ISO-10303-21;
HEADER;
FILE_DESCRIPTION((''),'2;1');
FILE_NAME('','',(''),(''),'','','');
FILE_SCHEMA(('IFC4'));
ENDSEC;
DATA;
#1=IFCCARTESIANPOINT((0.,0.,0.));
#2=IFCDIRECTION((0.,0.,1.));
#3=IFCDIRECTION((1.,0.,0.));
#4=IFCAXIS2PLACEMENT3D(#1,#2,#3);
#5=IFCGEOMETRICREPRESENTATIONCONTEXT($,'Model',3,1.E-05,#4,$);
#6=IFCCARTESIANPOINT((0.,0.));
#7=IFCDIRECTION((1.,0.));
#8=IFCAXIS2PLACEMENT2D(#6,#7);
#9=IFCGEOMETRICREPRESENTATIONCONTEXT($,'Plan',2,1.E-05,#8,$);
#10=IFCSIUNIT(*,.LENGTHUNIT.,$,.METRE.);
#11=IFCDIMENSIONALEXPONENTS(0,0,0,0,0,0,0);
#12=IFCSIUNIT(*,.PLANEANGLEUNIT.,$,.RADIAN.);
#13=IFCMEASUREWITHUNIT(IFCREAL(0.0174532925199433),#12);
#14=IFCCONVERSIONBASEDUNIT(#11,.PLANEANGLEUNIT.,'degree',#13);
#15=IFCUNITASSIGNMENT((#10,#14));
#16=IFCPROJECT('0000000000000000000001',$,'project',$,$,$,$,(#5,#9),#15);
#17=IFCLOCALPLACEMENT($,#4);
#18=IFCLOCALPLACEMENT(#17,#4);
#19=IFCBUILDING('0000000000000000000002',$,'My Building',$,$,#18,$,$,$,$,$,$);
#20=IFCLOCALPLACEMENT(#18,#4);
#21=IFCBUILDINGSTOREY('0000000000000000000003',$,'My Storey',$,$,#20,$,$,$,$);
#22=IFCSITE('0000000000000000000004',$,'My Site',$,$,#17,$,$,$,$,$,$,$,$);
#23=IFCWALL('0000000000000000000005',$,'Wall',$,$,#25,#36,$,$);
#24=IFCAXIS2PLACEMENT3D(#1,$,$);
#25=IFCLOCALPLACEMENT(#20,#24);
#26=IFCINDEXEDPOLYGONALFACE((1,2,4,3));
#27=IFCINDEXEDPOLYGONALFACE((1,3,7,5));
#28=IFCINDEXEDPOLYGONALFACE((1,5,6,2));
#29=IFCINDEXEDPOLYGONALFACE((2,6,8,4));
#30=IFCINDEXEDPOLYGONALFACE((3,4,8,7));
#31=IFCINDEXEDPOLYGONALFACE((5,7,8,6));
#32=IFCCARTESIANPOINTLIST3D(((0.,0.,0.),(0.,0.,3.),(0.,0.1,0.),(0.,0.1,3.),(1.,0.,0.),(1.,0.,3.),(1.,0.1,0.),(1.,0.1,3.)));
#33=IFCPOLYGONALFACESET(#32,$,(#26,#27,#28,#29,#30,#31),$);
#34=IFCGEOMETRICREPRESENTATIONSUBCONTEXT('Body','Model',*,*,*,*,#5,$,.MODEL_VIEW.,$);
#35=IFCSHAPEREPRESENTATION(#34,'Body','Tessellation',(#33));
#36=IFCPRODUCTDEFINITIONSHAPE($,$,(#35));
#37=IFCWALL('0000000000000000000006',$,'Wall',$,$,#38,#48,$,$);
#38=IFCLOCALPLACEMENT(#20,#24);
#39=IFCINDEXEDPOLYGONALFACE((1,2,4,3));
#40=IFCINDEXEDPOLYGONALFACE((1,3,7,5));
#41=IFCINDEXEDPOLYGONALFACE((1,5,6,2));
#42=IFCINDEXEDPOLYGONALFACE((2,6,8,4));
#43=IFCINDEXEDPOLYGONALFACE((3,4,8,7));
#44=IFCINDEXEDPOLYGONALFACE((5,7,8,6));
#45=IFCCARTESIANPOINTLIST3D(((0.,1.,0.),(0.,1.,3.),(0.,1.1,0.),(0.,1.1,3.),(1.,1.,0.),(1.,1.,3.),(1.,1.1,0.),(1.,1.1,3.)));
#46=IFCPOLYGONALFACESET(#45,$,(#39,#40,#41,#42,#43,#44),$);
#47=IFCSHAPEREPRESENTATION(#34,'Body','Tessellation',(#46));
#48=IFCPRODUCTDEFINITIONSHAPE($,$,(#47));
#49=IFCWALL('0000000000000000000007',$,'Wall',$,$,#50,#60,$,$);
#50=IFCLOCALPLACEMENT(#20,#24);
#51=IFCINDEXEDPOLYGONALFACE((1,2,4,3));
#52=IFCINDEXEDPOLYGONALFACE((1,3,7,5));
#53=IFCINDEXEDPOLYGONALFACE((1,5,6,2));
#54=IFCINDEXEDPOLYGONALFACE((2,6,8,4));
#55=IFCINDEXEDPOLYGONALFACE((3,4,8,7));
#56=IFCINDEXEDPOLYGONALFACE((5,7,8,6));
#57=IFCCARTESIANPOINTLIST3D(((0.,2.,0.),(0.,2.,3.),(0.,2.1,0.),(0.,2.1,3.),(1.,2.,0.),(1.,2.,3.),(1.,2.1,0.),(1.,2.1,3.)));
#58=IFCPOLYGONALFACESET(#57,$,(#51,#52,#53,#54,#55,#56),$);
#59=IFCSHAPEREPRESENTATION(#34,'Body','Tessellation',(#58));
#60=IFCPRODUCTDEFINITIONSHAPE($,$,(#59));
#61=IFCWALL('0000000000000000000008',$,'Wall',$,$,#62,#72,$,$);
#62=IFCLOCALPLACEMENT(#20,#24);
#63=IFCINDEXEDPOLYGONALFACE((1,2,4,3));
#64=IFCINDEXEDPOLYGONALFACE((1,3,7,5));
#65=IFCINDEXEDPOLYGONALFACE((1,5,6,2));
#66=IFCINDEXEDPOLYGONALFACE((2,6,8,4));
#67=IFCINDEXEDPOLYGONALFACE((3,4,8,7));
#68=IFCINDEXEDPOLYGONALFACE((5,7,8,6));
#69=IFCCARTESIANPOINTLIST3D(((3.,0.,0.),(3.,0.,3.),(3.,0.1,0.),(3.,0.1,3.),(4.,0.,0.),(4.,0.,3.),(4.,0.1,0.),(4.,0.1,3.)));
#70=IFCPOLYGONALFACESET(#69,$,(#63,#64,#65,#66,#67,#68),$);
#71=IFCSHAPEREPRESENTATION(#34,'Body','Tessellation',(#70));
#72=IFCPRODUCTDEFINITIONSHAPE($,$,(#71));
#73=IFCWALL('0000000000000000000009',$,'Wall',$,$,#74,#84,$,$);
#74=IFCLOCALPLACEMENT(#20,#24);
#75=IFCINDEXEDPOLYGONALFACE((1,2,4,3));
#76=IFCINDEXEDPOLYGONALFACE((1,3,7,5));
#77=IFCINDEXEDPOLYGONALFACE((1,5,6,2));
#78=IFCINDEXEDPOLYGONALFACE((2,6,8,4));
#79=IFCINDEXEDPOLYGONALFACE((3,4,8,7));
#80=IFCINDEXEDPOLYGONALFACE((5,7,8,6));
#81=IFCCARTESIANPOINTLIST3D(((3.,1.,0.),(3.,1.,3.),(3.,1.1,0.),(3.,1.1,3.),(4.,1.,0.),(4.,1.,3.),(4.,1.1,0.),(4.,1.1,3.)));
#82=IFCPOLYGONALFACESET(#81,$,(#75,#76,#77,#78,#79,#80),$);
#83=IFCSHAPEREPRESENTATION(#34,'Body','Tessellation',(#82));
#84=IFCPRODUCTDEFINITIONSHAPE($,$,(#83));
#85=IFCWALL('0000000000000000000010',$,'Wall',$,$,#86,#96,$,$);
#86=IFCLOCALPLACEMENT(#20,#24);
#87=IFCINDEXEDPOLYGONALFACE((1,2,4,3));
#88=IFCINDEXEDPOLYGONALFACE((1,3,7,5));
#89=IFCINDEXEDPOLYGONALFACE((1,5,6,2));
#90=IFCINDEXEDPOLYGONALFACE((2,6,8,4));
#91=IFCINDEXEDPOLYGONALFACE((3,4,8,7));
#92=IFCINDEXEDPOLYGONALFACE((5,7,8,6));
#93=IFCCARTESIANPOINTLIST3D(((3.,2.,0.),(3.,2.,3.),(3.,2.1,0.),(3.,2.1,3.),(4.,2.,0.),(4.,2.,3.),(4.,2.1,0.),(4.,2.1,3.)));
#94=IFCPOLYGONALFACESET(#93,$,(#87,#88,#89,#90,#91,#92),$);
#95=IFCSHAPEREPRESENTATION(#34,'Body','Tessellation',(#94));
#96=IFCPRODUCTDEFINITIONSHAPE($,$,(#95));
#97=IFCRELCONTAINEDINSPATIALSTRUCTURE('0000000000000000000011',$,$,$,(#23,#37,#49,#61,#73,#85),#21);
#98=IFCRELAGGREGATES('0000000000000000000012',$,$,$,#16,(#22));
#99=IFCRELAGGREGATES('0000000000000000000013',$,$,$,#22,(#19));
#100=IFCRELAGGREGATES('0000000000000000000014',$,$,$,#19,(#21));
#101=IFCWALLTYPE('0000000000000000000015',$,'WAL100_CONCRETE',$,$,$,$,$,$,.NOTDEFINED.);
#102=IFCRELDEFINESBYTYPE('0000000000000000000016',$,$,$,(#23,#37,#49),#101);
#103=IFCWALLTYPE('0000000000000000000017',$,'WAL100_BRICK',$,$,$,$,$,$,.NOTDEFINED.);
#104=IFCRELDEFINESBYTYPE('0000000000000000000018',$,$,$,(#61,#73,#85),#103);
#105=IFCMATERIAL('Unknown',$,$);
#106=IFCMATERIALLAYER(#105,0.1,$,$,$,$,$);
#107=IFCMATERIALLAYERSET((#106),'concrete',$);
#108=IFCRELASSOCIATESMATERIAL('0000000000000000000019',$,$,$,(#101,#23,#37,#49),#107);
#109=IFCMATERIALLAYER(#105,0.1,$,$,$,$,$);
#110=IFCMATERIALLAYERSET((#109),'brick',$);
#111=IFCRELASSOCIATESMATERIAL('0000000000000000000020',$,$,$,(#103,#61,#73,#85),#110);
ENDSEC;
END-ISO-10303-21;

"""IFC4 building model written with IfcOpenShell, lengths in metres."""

from ifc_helpers import new_model, entity, si_unit, converted_unit, frame, origin_with_axes, origin_2d_with_axis, place, context, subcontext, project, spatial, indexed_curve, outline, extrude, material, layer, layer_set, layer_usage, type_object, element, save


model = new_model("IFC4")

# Units and contexts
model_context = context("Model", 3, precision=1e-05, world=origin_with_axes())
plan_context = context("Plan", 2, precision=1e-05, world=origin_2d_with_axis())
body_context = subcontext(model_context, "Body", "Model", "MODEL_VIEW")
ifc_project = project(units=[si_unit("LENGTHUNIT", "METRE"), converted_unit("PLANEANGLEUNIT", "degree", entity("IfcReal", 0.0174532925199433), si_unit("PLANEANGLEUNIT", "RADIAN"), dimensions=[0, 0, 0, 0, 0, 0, 0])], contexts=[model_context, plan_context])

# Site, building, storey
site_placement = place(None, origin_with_axes())
site = spatial("IfcSite", under=ifc_project, at=site_placement, Name="My Site")
building_placement = place(site_placement, origin_with_axes())
building = spatial("IfcBuilding", under=site, at=building_placement, Name="My Building")
storey_placement = place(building_placement, origin_with_axes())
storey = spatial("IfcBuildingStorey", under=building, at=storey_placement, Name="My Storey")

# Walls
ifc_material = material(Name="Unknown")
ifc_layer_1 = layer(ifc_material, 0.1)
ifc_layer_set_1 = layer_set([ifc_layer_1], Name="concrete")
ifc_layer_usage_1 = layer_usage(ifc_layer_set_1, "AXIS2", "POSITIVE", 0.0)
wall_type_1 = type_object("IfcWallType", Name="WAL100_CONCRETE", PredefinedType="NOTDEFINED", material=ifc_layer_set_1)
wall_1_placement = place(storey_placement, origin_with_axes())
element("IfcWall", 1, at=wall_1_placement, inside=storey, type_object=wall_type_1, material=ifc_layer_usage_1, Name="Wall", context=body_context, shape_type="SweptSolid", body=[
    extrude(outline(indexed_curve([(0.0, 0.0), (0.0, 0.1), (1.0, 0.1), (1.0, 0.0), (0.0, 0.0)], self_intersect=False)), origin_with_axes(), (0.0, 0.0, 1.0), 3.0),
])
ifc_layer_usage_2 = layer_usage(ifc_layer_set_1, "AXIS2", "POSITIVE", 0.0)
wall_2_placement = place(storey_placement, frame((0.0, 1.0, 0.0), z_axis=(0.0, 0.0, 1.0), x_axis=(1.0, 0.0, 0.0)))
element("IfcWall", 2, at=wall_2_placement, inside=storey, type_object=wall_type_1, material=ifc_layer_usage_2, Name="Wall", context=body_context, shape_type="SweptSolid", body=[
    extrude(outline(indexed_curve([(0.0, 0.0), (0.0, 0.1), (1.0, 0.1), (1.0, 0.0), (0.0, 0.0)], self_intersect=False)), origin_with_axes(), (0.0, 0.0, 1.0), 3.0),
])
ifc_layer_usage_3 = layer_usage(ifc_layer_set_1, "AXIS2", "POSITIVE", 0.0)
wall_3_placement = place(storey_placement, frame((0.0, 2.0, 0.0), z_axis=(0.0, 0.0, 1.0), x_axis=(1.0, 0.0, 0.0)))
element("IfcWall", 3, at=wall_3_placement, inside=storey, type_object=wall_type_1, material=ifc_layer_usage_3, Name="Wall", context=body_context, shape_type="SweptSolid", body=[
    extrude(outline(indexed_curve([(0.0, 0.0), (0.0, 0.1), (1.0, 0.1), (1.0, 0.0), (0.0, 0.0)], self_intersect=False)), origin_with_axes(), (0.0, 0.0, 1.0), 3.0),
])
ifc_layer_2 = layer(ifc_material, 0.1)
ifc_layer_set_2 = layer_set([ifc_layer_2], Name="brick")
ifc_layer_usage_4 = layer_usage(ifc_layer_set_2, "AXIS2", "POSITIVE", 0.0)
wall_type_2 = type_object("IfcWallType", Name="WAL100_BRICK", PredefinedType="NOTDEFINED", material=ifc_layer_set_2)
wall_4_placement = place(storey_placement, frame((3.0, 0.0, 0.0), z_axis=(0.0, 0.0, 1.0), x_axis=(1.0, 0.0, 0.0)))
element("IfcWall", 4, at=wall_4_placement, inside=storey, type_object=wall_type_2, material=ifc_layer_usage_4, Name="Wall", context=body_context, shape_type="SweptSolid", body=[
    extrude(outline(indexed_curve([(0.0, 0.0), (0.0, 0.1), (1.0, 0.1), (1.0, 0.0), (0.0, 0.0)], self_intersect=False)), origin_with_axes(), (0.0, 0.0, 1.0), 3.0),
])
ifc_layer_usage_5 = layer_usage(ifc_layer_set_2, "AXIS2", "POSITIVE", 0.0)
wall_5_placement = place(storey_placement, frame((3.0, 1.0, 0.0), z_axis=(0.0, 0.0, 1.0), x_axis=(1.0, 0.0, 0.0)))
element("IfcWall", 5, at=wall_5_placement, inside=storey, type_object=wall_type_2, material=ifc_layer_usage_5, Name="Wall", context=body_context, shape_type="SweptSolid", body=[
    extrude(outline(indexed_curve([(0.0, 0.0), (0.0, 0.1), (1.0, 0.1), (1.0, 0.0), (0.0, 0.0)], self_intersect=False)), origin_with_axes(), (0.0, 0.0, 1.0), 3.0),
])
ifc_layer_usage_6 = layer_usage(ifc_layer_set_2, "AXIS2", "POSITIVE", 0.0)
wall_6_placement = place(storey_placement, frame((3.0, 2.0, 0.0), z_axis=(0.0, 0.0, 1.0), x_axis=(1.0, 0.0, 0.0)))
element("IfcWall", 6, at=wall_6_placement, inside=storey, type_object=wall_type_2, material=ifc_layer_usage_6, Name="Wall", context=body_context, shape_type="SweptSolid", body=[
    extrude(outline(indexed_curve([(0.0, 0.0), (0.0, 0.1), (1.0, 0.1), (1.0, 0.0), (0.0, 0.0)], self_intersect=False)), origin_with_axes(), (0.0, 0.0, 1.0), 3.0),
])

save(model, "model.ifc")
